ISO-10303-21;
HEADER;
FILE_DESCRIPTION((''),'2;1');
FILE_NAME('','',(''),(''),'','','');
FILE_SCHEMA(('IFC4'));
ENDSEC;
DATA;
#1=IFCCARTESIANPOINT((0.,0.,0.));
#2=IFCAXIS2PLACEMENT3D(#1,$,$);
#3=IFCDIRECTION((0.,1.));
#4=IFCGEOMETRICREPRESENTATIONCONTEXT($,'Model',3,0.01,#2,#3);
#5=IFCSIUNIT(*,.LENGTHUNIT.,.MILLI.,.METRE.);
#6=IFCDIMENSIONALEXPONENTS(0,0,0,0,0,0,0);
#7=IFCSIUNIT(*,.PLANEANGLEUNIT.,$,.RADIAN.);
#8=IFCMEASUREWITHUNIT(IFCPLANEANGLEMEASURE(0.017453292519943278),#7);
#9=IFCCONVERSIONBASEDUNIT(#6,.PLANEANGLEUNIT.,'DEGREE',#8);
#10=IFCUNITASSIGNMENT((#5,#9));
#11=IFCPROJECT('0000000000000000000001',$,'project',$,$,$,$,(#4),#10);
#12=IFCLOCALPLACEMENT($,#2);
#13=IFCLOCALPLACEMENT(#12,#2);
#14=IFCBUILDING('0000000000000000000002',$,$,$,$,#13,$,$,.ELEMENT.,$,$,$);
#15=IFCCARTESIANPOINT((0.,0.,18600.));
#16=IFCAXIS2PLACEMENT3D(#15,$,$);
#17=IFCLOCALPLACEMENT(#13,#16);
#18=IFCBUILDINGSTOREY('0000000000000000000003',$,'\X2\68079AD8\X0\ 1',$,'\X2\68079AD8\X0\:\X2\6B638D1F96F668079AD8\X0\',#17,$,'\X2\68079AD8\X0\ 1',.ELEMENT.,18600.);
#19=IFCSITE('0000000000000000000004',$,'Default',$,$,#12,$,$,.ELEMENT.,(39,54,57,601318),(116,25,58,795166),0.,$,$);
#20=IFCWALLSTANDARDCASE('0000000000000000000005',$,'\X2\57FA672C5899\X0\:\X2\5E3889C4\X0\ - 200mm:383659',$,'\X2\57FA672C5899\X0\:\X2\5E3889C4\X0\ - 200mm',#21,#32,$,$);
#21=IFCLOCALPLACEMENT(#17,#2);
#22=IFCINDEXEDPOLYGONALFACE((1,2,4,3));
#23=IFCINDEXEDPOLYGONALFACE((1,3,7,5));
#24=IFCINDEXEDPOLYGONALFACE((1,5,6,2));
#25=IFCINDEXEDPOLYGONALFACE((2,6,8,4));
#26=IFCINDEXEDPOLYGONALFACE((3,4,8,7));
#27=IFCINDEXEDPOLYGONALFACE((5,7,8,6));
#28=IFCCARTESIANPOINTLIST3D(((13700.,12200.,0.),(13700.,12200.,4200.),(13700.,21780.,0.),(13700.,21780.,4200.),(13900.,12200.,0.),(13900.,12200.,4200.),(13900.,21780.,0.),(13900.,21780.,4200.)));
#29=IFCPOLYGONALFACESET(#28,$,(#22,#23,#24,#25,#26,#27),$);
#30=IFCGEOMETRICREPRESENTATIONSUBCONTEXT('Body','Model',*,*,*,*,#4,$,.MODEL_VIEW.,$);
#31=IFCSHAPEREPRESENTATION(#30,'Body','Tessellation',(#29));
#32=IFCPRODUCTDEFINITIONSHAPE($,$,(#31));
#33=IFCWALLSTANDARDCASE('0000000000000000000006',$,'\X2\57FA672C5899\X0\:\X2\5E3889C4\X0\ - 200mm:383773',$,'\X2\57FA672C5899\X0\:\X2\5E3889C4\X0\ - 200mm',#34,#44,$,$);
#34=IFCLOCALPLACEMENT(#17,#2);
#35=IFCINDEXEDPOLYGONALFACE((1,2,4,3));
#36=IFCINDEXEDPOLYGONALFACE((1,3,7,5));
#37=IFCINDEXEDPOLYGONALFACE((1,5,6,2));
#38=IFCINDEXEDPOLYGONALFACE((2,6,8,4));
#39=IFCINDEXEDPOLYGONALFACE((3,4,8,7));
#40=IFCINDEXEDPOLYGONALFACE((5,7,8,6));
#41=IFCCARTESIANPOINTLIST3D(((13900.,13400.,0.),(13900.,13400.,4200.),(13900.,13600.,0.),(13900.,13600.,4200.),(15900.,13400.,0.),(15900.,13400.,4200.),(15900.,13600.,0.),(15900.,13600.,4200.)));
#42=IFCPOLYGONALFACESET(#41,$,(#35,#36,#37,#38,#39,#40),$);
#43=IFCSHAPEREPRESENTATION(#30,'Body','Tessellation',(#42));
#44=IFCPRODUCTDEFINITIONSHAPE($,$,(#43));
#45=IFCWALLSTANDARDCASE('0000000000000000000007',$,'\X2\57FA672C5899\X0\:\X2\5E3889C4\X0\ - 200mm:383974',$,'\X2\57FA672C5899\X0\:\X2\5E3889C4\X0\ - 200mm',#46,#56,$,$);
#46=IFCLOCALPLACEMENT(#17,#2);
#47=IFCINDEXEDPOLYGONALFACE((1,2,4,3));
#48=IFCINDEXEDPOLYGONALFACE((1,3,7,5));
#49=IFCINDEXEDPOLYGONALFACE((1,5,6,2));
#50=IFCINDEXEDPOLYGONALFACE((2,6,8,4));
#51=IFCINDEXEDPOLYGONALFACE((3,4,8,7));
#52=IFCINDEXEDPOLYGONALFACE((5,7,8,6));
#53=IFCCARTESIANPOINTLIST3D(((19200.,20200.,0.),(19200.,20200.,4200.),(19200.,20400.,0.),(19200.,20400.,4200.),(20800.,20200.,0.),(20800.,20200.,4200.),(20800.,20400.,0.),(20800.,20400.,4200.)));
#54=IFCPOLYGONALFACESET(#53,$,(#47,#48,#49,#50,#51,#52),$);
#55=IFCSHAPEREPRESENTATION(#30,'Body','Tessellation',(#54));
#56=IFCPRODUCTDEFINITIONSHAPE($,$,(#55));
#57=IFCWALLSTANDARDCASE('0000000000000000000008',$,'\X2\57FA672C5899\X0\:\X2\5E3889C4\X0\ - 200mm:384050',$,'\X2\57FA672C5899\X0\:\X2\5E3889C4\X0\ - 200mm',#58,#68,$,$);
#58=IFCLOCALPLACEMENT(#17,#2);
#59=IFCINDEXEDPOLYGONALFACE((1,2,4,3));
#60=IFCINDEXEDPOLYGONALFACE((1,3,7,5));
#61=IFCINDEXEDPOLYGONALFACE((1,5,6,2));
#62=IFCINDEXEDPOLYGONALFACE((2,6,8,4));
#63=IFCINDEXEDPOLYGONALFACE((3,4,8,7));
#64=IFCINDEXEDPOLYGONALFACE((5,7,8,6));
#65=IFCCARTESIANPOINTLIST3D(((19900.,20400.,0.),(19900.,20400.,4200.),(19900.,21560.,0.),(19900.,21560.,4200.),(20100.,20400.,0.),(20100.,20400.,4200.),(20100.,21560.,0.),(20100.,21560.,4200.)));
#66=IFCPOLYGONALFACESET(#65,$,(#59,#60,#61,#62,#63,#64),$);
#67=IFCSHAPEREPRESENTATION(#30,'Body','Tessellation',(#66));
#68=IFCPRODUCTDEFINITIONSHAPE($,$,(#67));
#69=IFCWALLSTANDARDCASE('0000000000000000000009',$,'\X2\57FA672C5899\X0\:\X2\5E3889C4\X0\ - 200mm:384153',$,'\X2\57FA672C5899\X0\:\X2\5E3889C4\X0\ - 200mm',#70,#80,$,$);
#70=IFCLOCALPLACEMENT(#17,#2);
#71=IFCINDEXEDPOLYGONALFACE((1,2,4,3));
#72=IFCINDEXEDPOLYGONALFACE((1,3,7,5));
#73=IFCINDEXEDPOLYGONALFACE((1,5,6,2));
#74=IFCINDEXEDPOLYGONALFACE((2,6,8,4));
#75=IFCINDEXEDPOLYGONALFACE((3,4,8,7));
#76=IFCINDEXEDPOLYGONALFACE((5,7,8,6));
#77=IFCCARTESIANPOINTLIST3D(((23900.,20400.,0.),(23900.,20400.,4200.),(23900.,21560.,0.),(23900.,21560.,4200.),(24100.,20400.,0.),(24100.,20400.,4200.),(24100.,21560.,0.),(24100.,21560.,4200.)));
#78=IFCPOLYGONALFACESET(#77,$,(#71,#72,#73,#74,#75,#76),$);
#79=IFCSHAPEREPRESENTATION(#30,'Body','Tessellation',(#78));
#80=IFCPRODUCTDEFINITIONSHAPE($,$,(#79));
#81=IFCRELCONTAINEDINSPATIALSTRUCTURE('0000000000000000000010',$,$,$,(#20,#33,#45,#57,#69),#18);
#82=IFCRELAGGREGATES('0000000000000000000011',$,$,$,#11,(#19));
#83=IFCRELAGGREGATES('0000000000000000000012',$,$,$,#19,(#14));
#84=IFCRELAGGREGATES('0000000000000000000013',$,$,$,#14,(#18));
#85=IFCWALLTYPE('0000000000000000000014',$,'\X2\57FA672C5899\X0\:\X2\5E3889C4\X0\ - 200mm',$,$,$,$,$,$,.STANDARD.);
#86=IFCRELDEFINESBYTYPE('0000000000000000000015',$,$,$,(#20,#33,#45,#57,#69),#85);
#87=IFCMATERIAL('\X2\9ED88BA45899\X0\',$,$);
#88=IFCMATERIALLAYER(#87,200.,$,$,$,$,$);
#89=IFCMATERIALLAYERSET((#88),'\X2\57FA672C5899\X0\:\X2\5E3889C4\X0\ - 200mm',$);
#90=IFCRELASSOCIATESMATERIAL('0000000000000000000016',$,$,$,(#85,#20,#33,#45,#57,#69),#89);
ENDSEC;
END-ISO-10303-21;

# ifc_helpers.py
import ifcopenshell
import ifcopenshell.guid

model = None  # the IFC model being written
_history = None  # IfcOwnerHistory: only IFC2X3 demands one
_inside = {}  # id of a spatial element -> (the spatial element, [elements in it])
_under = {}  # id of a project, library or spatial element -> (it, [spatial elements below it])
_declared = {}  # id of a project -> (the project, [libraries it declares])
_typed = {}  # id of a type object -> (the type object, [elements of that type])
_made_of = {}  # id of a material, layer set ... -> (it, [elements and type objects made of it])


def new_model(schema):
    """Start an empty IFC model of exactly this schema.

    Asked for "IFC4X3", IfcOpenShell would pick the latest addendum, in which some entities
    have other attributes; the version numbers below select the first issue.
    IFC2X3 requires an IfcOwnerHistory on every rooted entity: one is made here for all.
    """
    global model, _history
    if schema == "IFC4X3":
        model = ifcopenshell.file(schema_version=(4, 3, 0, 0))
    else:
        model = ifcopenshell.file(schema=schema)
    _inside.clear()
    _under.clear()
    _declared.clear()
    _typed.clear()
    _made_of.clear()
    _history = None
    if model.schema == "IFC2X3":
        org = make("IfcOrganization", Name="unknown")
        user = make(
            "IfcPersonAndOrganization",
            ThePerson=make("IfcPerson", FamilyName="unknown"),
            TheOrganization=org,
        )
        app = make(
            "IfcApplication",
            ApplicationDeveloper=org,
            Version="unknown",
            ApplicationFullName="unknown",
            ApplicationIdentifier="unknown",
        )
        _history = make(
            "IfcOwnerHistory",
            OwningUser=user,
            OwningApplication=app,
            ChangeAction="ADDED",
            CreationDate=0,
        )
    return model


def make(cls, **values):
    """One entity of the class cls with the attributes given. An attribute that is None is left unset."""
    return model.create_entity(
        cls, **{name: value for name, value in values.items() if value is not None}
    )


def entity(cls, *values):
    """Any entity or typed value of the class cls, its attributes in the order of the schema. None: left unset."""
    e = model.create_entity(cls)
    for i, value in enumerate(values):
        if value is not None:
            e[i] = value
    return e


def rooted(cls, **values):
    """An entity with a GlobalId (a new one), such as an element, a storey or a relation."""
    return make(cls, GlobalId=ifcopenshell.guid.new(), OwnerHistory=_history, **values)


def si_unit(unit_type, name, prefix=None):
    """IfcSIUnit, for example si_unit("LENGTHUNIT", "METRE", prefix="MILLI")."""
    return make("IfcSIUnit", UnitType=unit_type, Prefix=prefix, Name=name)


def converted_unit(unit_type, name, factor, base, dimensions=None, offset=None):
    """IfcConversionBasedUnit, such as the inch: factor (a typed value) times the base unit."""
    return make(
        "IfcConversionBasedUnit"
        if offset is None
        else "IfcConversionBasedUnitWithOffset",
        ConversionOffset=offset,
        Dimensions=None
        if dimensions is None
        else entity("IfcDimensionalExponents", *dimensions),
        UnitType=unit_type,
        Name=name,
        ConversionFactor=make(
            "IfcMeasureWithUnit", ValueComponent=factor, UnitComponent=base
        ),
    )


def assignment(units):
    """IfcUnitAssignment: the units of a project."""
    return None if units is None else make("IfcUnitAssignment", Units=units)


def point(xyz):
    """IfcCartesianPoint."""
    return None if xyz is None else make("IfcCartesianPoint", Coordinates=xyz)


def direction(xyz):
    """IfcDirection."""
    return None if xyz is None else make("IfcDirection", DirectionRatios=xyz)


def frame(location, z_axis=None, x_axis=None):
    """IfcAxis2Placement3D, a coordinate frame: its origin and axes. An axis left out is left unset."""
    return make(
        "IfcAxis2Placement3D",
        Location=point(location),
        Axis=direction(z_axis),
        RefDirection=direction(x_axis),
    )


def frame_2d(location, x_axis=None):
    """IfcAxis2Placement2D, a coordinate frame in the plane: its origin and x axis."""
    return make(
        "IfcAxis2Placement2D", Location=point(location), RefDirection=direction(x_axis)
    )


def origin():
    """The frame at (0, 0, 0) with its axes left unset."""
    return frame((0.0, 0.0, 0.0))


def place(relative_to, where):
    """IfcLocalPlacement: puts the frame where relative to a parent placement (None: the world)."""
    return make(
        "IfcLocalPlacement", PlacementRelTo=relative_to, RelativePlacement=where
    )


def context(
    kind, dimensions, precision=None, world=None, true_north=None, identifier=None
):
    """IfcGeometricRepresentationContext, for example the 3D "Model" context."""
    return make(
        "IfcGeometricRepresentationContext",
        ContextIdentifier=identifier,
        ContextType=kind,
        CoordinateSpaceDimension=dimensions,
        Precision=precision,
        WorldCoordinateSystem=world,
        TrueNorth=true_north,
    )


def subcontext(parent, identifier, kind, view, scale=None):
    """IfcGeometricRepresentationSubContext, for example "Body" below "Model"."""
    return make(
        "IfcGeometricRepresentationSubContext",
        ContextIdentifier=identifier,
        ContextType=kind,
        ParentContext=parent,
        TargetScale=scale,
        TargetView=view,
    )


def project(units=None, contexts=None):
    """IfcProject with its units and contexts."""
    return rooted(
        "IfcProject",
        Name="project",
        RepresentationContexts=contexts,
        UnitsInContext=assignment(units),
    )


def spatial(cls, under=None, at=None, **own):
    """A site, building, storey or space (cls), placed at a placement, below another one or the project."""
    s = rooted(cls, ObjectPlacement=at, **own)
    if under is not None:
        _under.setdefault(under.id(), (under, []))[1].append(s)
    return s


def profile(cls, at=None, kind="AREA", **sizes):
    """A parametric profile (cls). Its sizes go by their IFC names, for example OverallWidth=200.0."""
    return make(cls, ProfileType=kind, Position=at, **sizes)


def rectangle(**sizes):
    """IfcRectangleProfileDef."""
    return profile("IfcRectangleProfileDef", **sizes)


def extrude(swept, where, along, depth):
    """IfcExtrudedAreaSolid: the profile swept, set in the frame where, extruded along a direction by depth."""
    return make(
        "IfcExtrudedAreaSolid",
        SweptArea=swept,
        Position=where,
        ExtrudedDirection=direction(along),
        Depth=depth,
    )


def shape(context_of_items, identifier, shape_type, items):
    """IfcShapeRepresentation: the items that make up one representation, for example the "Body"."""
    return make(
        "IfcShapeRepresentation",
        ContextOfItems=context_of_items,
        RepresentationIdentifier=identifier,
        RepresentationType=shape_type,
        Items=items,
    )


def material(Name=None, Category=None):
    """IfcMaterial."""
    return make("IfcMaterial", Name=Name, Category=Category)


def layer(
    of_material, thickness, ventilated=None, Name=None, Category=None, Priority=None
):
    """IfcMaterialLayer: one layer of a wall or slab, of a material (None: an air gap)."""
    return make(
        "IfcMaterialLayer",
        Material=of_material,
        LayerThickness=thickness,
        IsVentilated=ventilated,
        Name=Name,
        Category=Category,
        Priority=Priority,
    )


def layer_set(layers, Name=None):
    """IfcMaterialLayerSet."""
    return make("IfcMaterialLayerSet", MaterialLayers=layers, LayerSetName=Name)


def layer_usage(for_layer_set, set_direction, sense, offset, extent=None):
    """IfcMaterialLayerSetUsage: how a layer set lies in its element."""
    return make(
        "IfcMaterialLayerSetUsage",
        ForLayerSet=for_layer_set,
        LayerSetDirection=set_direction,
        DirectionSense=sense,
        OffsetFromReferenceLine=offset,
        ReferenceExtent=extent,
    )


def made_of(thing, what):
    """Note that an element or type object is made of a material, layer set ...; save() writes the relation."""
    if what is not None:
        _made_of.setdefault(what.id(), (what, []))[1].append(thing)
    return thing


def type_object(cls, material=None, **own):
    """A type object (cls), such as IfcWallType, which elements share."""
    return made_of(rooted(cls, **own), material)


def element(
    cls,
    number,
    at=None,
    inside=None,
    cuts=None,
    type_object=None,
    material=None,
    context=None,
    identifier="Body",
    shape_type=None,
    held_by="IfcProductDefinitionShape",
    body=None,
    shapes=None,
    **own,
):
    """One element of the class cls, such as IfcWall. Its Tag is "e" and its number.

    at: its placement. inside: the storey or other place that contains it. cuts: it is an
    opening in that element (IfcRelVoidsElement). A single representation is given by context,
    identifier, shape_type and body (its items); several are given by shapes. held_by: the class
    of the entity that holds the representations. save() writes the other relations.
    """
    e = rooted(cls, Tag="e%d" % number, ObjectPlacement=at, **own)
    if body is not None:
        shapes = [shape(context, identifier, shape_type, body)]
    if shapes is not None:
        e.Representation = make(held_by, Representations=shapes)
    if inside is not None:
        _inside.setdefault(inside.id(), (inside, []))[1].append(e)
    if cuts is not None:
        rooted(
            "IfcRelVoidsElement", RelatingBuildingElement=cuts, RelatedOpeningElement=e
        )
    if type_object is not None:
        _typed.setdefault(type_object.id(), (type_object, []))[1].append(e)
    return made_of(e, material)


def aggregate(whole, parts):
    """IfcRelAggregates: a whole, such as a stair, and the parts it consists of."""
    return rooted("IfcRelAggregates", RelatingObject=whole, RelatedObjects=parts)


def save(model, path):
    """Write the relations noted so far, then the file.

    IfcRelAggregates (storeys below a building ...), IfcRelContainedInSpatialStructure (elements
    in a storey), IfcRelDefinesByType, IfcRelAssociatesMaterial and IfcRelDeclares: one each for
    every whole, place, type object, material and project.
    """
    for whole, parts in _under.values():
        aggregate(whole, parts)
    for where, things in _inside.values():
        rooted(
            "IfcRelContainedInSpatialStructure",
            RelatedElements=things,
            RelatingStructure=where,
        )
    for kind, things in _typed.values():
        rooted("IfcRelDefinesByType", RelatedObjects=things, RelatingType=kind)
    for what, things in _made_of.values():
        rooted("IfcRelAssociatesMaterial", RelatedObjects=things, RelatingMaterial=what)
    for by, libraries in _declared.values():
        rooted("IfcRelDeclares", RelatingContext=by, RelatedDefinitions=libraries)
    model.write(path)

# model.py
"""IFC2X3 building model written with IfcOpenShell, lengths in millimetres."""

from ifc_helpers import new_model, entity, si_unit, converted_unit, direction, frame, frame_2d, origin, place, context, subcontext, project, spatial, rectangle, extrude, material, layer, layer_set, layer_usage, type_object, element, save


model = new_model("IFC2X3")

# Units and contexts
model_context = context("Model", 3, precision=0.01, world=origin(), true_north=direction((0.0, 1.0)))
body_context = subcontext(model_context, "Body", "Model", "MODEL_VIEW")
ifc_project = project(units=[si_unit("LENGTHUNIT", "METRE", prefix="MILLI"), converted_unit("PLANEANGLEUNIT", "DEGREE", entity("IfcPlaneAngleMeasure", 0.017453292519943278), si_unit("PLANEANGLEUNIT", "RADIAN"), dimensions=[0, 0, 0, 0, 0, 0, 0])], contexts=[model_context])

# Site, building, storey
site_placement = place(None, origin())
site = spatial("IfcSite", under=ifc_project, at=site_placement, Name="Default", CompositionType="ELEMENT", RefLatitude=(39, 54, 57, 601318), RefLongitude=(116, 25, 58, 795166), RefElevation=0.0)
building_placement = place(site_placement, origin())
building = spatial("IfcBuilding", under=site, at=building_placement, CompositionType="ELEMENT")
storey_placement = place(building_placement, frame((0.0, 0.0, 18600.0)))
storey = spatial("IfcBuildingStorey", under=building, at=storey_placement, Name="标高 1", ObjectType="标高:正负零标高", LongName="标高 1", CompositionType="ELEMENT", Elevation=18600.0)

# Walls
ifc_material_1 = material(Name="默认墙")
ifc_layer = layer(ifc_material_1, 200.0)
ifc_layer_set = layer_set([ifc_layer], Name="基本墙:常规 - 200mm")
wall_type = type_object("IfcWallType", Name="基本墙:常规 - 200mm", PredefinedType="STANDARD", material=ifc_layer_set)
ifc_layer_usage_1 = layer_usage(ifc_layer_set, "AXIS2", "NEGATIVE", 100.0)
wall_1_placement = place(storey_placement, frame((13800.0, 21780.0, 0.0), z_axis=(0.0, 0.0, 1.0), x_axis=(0.0, -1.0, 0.0)))
element("IfcWallStandardCase", 1, at=wall_1_placement, inside=storey, type_object=wall_type, material=ifc_layer_usage_1, Name="基本墙:常规 - 200mm:383659", ObjectType="基本墙:常规 - 200mm", context=body_context, shape_type="SweptSolid", body=[
    extrude(rectangle(XDim=9580.0, YDim=200.0, at=frame_2d((4790.0, 0.0), x_axis=(-1.0, 0.0))), origin(), (0.0, 0.0, 1.0), 4200.0),
])
ifc_layer_usage_2 = layer_usage(ifc_layer_set, "AXIS2", "NEGATIVE", 100.0)
wall_2_placement = place(storey_placement, frame((13900.0, 13500.0, 0.0)))
element("IfcWallStandardCase", 2, at=wall_2_placement, inside=storey, type_object=wall_type, material=ifc_layer_usage_2, Name="基本墙:常规 - 200mm:383773", ObjectType="基本墙:常规 - 200mm", context=body_context, shape_type="SweptSolid", body=[
    extrude(rectangle(XDim=2000.0, YDim=200.0, at=frame_2d((1000.0, 0.0), x_axis=(-1.0, 0.0))), origin(), (0.0, 0.0, 1.0), 4200.0),
])
ifc_layer_usage_3 = layer_usage(ifc_layer_set, "AXIS2", "NEGATIVE", 100.0)
wall_3_placement = place(storey_placement, frame((19200.0, 20300.0, 0.0)))
element("IfcWallStandardCase", 3, at=wall_3_placement, inside=storey, type_object=wall_type, material=ifc_layer_usage_3, Name="基本墙:常规 - 200mm:383974", ObjectType="基本墙:常规 - 200mm", context=body_context, shape_type="SweptSolid", body=[
    extrude(rectangle(XDim=1600.0, YDim=200.0, at=frame_2d((800.0, 0.0), x_axis=(-1.0, 0.0))), origin(), (0.0, 0.0, 1.0), 4200.0),
])
ifc_layer_usage_4 = layer_usage(ifc_layer_set, "AXIS2", "NEGATIVE", 100.0)
wall_4_placement = place(storey_placement, frame((20000.0, 20400.0, 0.0), z_axis=(0.0, 0.0, 1.0), x_axis=(0.0, 1.0, 0.0)))
element("IfcWallStandardCase", 4, at=wall_4_placement, inside=storey, type_object=wall_type, material=ifc_layer_usage_4, Name="基本墙:常规 - 200mm:384050", ObjectType="基本墙:常规 - 200mm", context=body_context, shape_type="SweptSolid", body=[
    extrude(rectangle(XDim=1160.0, YDim=200.0, at=frame_2d((580.0, 0.0), x_axis=(-1.0, 0.0))), origin(), (0.0, 0.0, 1.0), 4200.0),
])
ifc_layer_usage_5 = layer_usage(ifc_layer_set, "AXIS2", "NEGATIVE", 100.0)
wall_5_placement = place(storey_placement, frame((24000.0, 21560.0, 0.0), z_axis=(0.0, 0.0, 1.0), x_axis=(0.0, -1.0, 0.0)))
element("IfcWallStandardCase", 5, at=wall_5_placement, inside=storey, type_object=wall_type, material=ifc_layer_usage_5, Name="基本墙:常规 - 200mm:384153", ObjectType="基本墙:常规 - 200mm", context=body_context, shape_type="SweptSolid", body=[
    extrude(rectangle(XDim=1160.0, YDim=200.0, at=frame_2d((580.0, 0.0), x_axis=(-1.0, 0.0))), origin(), (0.0, 0.0, 1.0), 4200.0),
])

save(model, "model.ifc")
